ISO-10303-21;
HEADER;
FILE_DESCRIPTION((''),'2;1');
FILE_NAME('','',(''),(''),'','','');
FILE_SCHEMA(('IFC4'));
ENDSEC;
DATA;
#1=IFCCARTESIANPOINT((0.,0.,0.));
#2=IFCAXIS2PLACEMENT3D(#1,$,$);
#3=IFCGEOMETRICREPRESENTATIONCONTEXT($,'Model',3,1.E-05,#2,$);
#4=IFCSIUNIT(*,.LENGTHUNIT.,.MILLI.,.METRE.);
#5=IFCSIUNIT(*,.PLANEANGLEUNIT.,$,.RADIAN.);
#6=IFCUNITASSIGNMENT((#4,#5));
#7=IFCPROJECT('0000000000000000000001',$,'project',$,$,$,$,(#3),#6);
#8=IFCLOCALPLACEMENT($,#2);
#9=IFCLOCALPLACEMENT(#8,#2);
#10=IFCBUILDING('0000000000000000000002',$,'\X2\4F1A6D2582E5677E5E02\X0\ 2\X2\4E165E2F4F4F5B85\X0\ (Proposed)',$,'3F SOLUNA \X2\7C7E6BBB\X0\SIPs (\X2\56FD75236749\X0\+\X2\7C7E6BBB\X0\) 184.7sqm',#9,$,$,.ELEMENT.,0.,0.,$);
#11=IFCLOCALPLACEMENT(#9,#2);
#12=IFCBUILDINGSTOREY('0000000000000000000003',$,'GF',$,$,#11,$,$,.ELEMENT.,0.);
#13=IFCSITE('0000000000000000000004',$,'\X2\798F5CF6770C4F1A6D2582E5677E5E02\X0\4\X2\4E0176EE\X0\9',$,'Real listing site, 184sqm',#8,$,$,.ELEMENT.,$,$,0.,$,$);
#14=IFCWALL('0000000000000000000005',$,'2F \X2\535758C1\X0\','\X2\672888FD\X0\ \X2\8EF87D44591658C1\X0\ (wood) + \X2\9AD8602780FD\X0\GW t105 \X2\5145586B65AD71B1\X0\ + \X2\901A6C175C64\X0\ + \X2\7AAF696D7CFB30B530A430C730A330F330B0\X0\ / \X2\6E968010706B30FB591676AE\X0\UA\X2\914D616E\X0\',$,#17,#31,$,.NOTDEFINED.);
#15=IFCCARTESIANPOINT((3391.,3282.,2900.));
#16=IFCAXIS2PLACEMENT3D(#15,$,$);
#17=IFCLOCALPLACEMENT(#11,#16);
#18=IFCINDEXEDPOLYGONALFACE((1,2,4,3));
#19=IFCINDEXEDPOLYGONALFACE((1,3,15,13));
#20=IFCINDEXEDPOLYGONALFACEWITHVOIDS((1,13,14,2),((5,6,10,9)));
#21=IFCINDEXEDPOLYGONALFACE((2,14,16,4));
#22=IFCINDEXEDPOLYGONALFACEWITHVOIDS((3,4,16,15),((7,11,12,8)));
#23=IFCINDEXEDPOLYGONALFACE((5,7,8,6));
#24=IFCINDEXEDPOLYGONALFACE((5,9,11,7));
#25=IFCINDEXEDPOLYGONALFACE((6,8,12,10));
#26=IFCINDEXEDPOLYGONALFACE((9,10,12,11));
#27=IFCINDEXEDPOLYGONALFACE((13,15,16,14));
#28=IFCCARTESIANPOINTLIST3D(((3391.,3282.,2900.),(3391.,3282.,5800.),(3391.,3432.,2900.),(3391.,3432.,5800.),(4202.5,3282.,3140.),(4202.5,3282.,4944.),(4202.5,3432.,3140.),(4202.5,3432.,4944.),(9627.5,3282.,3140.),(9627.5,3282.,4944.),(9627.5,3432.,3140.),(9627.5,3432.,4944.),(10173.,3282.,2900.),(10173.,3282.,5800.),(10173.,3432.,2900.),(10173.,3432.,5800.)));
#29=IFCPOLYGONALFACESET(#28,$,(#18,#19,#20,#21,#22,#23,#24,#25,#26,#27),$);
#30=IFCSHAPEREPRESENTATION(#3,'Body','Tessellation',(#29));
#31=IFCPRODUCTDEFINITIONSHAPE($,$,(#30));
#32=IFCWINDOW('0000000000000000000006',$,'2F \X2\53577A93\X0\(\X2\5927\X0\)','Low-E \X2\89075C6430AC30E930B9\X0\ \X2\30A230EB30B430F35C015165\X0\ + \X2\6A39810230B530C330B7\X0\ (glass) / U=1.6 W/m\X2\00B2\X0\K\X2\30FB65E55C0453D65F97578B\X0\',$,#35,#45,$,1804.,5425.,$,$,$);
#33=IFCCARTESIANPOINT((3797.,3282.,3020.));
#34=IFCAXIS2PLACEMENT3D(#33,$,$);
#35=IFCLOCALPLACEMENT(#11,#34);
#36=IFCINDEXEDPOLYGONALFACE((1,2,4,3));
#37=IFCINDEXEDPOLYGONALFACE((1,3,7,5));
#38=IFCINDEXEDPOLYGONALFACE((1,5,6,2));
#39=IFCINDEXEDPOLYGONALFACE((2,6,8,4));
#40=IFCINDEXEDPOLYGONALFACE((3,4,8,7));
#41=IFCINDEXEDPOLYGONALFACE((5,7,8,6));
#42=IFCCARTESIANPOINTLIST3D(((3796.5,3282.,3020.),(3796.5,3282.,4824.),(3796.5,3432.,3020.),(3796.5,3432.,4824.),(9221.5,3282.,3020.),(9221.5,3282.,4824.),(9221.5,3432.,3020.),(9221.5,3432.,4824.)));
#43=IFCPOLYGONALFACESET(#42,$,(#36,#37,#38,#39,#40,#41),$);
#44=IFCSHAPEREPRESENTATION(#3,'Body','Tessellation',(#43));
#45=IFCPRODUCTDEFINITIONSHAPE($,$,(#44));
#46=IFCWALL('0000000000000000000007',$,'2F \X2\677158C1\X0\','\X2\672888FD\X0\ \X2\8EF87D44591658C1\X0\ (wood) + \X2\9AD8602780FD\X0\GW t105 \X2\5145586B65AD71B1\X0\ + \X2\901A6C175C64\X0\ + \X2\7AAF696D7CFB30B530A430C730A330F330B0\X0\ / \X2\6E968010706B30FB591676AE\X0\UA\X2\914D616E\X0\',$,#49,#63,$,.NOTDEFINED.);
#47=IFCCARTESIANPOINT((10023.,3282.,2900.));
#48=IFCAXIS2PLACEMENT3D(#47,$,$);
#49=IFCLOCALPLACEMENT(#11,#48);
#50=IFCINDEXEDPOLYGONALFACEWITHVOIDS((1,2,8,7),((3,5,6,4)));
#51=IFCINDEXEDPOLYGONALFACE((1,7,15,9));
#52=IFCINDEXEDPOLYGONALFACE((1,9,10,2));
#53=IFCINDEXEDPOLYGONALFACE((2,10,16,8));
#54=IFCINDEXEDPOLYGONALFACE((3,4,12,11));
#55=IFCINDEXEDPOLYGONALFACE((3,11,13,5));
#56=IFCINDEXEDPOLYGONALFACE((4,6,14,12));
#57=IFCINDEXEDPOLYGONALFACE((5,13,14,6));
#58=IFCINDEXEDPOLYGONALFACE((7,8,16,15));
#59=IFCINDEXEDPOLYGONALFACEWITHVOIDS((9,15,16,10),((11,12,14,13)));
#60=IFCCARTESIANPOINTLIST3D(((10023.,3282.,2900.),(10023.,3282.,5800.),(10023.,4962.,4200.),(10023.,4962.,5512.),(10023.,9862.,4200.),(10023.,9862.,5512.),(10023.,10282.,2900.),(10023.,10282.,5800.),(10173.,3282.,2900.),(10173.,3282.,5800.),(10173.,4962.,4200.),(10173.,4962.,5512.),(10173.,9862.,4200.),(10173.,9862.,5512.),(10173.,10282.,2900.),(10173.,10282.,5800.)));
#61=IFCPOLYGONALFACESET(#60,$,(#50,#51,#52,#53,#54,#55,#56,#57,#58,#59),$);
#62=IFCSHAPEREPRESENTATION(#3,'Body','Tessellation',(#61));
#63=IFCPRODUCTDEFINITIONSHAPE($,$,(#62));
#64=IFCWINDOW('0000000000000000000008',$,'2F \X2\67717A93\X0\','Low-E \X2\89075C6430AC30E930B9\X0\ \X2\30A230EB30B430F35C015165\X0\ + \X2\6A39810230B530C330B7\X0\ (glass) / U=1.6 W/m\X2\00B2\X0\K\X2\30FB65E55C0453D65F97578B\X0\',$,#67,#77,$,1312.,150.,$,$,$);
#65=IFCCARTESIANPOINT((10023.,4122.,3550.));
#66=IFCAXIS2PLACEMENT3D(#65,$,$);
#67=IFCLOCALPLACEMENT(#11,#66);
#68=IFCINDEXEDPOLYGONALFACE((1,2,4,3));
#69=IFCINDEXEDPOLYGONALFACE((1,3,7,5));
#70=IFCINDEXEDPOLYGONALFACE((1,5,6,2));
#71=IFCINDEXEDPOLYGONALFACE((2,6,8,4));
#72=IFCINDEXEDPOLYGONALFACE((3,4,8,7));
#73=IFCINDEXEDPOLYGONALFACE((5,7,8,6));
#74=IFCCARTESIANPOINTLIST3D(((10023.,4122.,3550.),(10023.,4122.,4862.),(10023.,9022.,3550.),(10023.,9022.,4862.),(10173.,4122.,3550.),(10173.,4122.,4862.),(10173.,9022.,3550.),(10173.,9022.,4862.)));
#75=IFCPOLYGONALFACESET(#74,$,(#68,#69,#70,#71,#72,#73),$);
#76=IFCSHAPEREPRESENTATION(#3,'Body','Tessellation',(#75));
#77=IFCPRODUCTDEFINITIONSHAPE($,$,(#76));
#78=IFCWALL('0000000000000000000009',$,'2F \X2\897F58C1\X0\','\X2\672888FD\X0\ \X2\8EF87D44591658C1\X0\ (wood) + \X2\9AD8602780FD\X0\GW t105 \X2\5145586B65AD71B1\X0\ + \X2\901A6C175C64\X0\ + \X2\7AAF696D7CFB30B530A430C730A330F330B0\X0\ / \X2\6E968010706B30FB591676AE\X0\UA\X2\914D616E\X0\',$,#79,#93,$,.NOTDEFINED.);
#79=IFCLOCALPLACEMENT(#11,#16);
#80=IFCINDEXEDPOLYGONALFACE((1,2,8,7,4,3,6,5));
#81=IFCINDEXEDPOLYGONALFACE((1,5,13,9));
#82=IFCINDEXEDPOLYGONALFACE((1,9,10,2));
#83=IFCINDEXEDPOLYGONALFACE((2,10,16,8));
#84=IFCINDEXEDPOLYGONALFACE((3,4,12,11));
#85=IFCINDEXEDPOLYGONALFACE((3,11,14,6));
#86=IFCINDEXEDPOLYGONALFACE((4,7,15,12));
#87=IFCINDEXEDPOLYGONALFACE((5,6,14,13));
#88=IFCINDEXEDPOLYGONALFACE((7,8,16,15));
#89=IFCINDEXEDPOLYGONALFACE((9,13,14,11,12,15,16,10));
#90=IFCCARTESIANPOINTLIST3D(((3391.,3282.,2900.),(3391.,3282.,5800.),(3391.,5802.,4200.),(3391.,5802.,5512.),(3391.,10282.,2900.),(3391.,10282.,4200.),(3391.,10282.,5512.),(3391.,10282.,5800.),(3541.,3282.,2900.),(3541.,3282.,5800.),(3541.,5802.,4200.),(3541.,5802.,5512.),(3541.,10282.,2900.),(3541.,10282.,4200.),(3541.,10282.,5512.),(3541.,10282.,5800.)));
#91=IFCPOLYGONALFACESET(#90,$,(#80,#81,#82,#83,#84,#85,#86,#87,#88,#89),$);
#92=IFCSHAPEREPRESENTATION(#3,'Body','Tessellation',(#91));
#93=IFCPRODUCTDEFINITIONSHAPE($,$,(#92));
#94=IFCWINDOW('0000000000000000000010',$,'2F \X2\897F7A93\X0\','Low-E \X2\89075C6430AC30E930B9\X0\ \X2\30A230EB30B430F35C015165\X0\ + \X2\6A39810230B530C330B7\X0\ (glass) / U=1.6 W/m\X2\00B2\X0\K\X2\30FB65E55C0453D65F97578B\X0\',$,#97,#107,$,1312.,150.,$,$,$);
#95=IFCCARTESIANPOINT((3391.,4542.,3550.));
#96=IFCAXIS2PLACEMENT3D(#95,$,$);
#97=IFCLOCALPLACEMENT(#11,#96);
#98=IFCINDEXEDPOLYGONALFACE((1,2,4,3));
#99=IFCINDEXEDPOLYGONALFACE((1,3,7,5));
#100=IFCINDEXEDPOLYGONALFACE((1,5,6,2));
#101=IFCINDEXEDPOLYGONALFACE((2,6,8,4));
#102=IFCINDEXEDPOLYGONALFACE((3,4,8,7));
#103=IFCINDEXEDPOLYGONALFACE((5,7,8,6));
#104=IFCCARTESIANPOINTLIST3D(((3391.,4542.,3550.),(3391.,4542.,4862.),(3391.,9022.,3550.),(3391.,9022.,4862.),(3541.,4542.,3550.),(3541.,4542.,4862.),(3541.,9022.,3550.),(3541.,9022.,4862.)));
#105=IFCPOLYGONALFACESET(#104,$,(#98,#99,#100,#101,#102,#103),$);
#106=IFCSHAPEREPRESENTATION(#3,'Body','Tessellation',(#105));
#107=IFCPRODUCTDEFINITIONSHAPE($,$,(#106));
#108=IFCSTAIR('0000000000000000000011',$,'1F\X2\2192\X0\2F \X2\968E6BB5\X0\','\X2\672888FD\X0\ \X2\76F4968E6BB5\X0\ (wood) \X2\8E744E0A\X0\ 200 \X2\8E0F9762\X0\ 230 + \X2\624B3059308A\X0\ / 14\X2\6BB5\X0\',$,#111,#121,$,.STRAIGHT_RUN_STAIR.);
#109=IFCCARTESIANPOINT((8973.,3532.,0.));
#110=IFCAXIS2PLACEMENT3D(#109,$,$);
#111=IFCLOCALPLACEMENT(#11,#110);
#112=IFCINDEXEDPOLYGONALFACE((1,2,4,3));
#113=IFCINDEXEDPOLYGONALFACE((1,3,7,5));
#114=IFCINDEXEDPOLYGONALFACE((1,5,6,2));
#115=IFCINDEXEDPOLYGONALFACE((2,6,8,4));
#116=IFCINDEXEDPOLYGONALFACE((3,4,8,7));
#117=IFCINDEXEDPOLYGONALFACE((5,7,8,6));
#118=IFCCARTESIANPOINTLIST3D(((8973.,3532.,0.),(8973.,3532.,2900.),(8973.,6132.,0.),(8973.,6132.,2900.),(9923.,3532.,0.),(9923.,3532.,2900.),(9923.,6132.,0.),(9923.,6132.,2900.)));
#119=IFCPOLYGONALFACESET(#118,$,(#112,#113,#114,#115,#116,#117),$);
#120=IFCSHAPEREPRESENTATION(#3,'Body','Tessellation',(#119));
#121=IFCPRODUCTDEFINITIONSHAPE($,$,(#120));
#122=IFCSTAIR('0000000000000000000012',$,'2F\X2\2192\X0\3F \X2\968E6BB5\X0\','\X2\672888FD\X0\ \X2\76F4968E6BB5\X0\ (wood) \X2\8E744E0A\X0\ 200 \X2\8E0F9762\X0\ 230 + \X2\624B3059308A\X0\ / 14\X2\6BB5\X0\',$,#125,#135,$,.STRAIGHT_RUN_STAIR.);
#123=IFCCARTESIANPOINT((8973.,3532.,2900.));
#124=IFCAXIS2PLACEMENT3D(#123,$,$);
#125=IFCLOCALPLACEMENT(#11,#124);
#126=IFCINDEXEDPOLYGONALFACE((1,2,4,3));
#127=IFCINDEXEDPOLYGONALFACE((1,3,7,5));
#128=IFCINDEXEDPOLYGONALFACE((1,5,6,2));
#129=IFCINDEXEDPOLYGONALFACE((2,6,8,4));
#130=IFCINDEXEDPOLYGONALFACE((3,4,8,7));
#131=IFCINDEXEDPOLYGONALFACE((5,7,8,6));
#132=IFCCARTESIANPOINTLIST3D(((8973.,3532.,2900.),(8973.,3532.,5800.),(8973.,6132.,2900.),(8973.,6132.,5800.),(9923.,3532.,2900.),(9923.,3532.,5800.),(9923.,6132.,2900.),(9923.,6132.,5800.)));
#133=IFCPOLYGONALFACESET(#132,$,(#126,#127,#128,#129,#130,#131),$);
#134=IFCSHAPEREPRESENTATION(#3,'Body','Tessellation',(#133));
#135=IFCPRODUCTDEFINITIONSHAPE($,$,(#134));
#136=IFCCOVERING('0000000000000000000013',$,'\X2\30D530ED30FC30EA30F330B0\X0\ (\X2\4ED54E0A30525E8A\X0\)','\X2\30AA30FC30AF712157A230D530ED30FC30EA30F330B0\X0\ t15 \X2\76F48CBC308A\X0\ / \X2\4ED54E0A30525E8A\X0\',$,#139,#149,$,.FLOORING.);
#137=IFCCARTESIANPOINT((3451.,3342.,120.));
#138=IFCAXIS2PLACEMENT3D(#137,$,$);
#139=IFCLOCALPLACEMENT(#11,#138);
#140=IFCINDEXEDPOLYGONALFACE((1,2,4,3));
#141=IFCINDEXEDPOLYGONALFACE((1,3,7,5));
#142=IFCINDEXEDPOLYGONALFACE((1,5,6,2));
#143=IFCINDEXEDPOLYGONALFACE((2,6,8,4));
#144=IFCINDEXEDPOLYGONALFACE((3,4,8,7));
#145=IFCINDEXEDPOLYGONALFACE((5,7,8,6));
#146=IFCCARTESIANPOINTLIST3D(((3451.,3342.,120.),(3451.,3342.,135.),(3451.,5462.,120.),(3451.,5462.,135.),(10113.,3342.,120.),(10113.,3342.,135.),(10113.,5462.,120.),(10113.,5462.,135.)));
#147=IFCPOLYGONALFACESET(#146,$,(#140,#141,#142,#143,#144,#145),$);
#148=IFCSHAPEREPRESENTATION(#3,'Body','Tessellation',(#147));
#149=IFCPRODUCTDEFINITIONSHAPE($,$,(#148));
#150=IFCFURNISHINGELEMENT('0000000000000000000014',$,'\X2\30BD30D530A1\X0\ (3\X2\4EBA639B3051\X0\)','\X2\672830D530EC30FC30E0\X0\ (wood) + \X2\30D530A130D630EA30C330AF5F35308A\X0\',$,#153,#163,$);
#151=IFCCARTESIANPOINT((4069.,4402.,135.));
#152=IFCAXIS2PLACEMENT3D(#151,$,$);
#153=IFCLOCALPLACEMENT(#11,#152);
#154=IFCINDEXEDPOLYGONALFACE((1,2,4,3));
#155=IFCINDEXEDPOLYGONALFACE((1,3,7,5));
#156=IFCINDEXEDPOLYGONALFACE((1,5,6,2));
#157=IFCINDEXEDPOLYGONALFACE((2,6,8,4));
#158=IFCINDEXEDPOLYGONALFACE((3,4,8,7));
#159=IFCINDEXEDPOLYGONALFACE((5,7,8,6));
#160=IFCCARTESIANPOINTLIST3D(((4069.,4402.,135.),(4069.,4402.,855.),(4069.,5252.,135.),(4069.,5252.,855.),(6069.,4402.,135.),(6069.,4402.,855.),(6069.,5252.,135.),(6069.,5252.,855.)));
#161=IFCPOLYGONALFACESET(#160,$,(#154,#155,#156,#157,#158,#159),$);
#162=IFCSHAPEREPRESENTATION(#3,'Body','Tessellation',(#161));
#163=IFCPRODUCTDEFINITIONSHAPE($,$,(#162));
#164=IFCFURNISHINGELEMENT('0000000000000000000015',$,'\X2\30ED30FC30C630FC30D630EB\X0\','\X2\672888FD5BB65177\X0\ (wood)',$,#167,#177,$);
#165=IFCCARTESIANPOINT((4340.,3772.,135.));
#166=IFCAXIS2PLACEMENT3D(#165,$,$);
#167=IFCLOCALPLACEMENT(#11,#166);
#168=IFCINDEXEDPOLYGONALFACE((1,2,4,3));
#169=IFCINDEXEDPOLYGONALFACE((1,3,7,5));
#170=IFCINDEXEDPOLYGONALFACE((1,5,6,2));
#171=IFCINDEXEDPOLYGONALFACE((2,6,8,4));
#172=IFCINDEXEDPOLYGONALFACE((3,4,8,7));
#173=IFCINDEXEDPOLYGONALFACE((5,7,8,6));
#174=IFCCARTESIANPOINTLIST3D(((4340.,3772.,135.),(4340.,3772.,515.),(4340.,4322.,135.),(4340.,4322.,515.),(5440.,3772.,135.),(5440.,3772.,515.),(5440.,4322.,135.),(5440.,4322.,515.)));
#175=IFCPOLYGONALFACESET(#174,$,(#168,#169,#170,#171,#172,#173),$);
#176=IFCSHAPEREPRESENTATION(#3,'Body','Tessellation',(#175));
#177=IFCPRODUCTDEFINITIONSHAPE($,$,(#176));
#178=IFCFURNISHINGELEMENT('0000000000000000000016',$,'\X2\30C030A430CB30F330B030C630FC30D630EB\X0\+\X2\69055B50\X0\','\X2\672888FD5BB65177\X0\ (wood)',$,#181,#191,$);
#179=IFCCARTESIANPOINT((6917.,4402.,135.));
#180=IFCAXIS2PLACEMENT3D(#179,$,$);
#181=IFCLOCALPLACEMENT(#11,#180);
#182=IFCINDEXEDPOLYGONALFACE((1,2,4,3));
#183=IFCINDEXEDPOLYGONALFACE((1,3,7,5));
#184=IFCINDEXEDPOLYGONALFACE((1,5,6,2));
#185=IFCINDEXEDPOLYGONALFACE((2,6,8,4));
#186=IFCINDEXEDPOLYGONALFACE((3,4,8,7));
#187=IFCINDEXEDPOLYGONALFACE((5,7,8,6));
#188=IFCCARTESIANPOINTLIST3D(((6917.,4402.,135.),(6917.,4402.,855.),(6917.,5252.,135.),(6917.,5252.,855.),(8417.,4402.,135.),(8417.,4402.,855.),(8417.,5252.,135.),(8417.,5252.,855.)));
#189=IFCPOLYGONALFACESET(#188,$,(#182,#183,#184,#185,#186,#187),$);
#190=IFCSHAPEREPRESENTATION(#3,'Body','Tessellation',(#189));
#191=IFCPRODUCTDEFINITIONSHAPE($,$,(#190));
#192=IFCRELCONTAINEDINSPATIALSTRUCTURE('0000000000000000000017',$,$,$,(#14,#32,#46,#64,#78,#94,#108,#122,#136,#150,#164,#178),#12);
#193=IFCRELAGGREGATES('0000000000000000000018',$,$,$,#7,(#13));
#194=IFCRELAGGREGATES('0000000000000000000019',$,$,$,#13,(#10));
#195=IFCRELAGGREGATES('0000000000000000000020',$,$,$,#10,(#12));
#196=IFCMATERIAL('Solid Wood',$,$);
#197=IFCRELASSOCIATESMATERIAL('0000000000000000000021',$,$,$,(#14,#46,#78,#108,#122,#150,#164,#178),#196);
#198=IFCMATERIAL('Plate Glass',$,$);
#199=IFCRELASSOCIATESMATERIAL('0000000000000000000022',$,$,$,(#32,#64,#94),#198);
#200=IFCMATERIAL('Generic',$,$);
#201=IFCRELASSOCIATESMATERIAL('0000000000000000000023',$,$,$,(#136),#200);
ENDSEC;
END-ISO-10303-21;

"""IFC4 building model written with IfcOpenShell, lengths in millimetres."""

from ifc_helpers import new_model, si_unit, frame, frame_2d, origin, place, context, project, spatial, rectangle, extrude, material, element, fill, save


model = new_model("IFC4")

# Units and contexts
model_context = context("Model", 3, precision=1e-05, world=origin())
ifc_project = project(units=[si_unit("LENGTHUNIT", "METRE", prefix="MILLI"), si_unit("PLANEANGLEUNIT", "RADIAN")], contexts=[model_context])

# Site, building, storey
site_placement = place(None, origin())
site = spatial("IfcSite", under=ifc_project, at=site_placement, Name="福島県会津若松市4丁目9", ObjectType="Real listing site, 184sqm", CompositionType="ELEMENT", RefElevation=0.0)
building_placement = place(site_placement, origin())
building = spatial("IfcBuilding", under=site, at=building_placement, Name="会津若松市 2世帯住宅 (Proposed)", ObjectType="3F SOLUNA 籾殻SIPs (国産杉+籾殻) 184.7sqm", CompositionType="ELEMENT", ElevationOfRefHeight=0.0, ElevationOfTerrain=0.0)
storey_placement = place(building_placement, origin())
storey = spatial("IfcBuildingStorey", under=building, at=storey_placement, Name="GF", CompositionType="ELEMENT", Elevation=0.0)

# Shared definitions
ifc_material_1 = material(Name="Solid Wood")
ifc_material_2 = material(Name="Generic")

# Shared definitions
ifc_material_3 = material(Name="Plate Glass")

# Walls, openings, windows
wall_1_placement = place(storey_placement, frame((3391.0, 3282.0, 2900.0)))
wall_1 = element("IfcWall", 1, at=wall_1_placement, inside=storey, material=ifc_material_1, Name="2F 南壁", Description="木製 軸組外壁 (wood) + 高性能GW t105 充填断熱 + 通気層 + 窯業系サイディング / 準耐火・外皮UA配慮", PredefinedType="NOTDEFINED", context=model_context, shape_type="SweptSolid", body=[
    extrude(rectangle(XDim=6782.0, YDim=150.0, at=frame_2d((3391.0, 75.0))), frame((3391.0, 3282.0, 2900.0)), (0.0, 0.0, 1.0), 2900.0),
])
opening_1_placement = place(storey_placement, frame((3797.0, 3282.0, 3020.0)))
opening_1 = element("IfcOpeningElement", 2, at=opening_1_placement, cuts=wall_1, PredefinedType="NOTDEFINED", context=model_context, shape_type="SweptSolid", body=[
    extrude(rectangle(XDim=5425.0, YDim=150.0, at=frame_2d((2712.0, 75.0))), frame((3797.0, 3282.0, 3020.0)), (0.0, 0.0, 1.0), 1804.0),
])
window_1_placement = place(storey_placement, frame((3797.0, 3282.0, 3020.0)))
window_1 = element("IfcWindow", 3, at=window_1_placement, inside=storey, material=ifc_material_3, Name="2F 南窓(大)", Description="Low-E 複層ガラス アルゴン封入 + 樹脂サッシ (glass) / U=1.6 W/m²K・日射取得型", OverallHeight=1804.0, OverallWidth=5425.0, context=model_context, shape_type="SweptSolid", body=[
    extrude(rectangle(XDim=5425.0, YDim=150.0, at=frame_2d((2712.0, 75.0))), frame((3797.0, 3282.0, 3020.0)), (0.0, 0.0, 1.0), 1804.0),
])
fill(opening_1, window_1)
wall_2_placement = place(storey_placement, frame((10023.0, 3282.0, 2900.0)))
wall_2 = element("IfcWall", 4, at=wall_2_placement, inside=storey, material=ifc_material_1, Name="2F 東壁", Description="木製 軸組外壁 (wood) + 高性能GW t105 充填断熱 + 通気層 + 窯業系サイディング / 準耐火・外皮UA配慮", PredefinedType="NOTDEFINED", context=model_context, shape_type="SweptSolid", body=[
    extrude(rectangle(XDim=150.0, YDim=7000.0, at=frame_2d((75.0, 3500.0))), frame((10023.0, 3282.0, 2900.0)), (0.0, 0.0, 1.0), 2900.0),
])
opening_2_placement = place(storey_placement, frame((10023.0, 4122.0, 3550.0)))
opening_2 = element("IfcOpeningElement", 5, at=opening_2_placement, cuts=wall_2, PredefinedType="NOTDEFINED", context=model_context, shape_type="SweptSolid", body=[
    extrude(rectangle(XDim=150.0, YDim=4900.0, at=frame_2d((75.0, 2450.0))), frame((10023.0, 4122.0, 3550.0)), (0.0, 0.0, 1.0), 1312.0),
])
window_2_placement = place(storey_placement, frame((10023.0, 4122.0, 3550.0)))
window_2 = element("IfcWindow", 6, at=window_2_placement, inside=storey, material=ifc_material_3, Name="2F 東窓", Description="Low-E 複層ガラス アルゴン封入 + 樹脂サッシ (glass) / U=1.6 W/m²K・日射取得型", OverallHeight=1312.0, OverallWidth=150.0, context=model_context, shape_type="SweptSolid", body=[
    extrude(rectangle(XDim=150.0, YDim=4900.0, at=frame_2d((75.0, 2450.0))), frame((10023.0, 4122.0, 3550.0)), (0.0, 0.0, 1.0), 1312.0),
])
fill(opening_2, window_2)
wall_3_placement = place(storey_placement, frame((3391.0, 3282.0, 2900.0)))
wall_3 = element("IfcWall", 7, at=wall_3_placement, inside=storey, material=ifc_material_1, Name="2F 西壁", Description="木製 軸組外壁 (wood) + 高性能GW t105 充填断熱 + 通気層 + 窯業系サイディング / 準耐火・外皮UA配慮", PredefinedType="NOTDEFINED", context=model_context, shape_type="SweptSolid", body=[
    extrude(rectangle(XDim=150.0, YDim=7000.0, at=frame_2d((75.0, 3500.0))), frame((3391.0, 3282.0, 2900.0)), (0.0, 0.0, 1.0), 2900.0),
])
opening_3_placement = place(storey_placement, frame((3391.0, 4542.0, 3550.0)))
opening_3 = element("IfcOpeningElement", 8, at=opening_3_placement, cuts=wall_3, PredefinedType="NOTDEFINED", context=model_context, shape_type="SweptSolid", body=[
    extrude(rectangle(XDim=150.0, YDim=4480.0, at=frame_2d((75.0, 2240.0))), frame((3391.0, 4542.0, 3550.0)), (0.0, 0.0, 1.0), 1312.0),
])
window_3_placement = place(storey_placement, frame((3391.0, 4542.0, 3550.0)))
window_3 = element("IfcWindow", 9, at=window_3_placement, inside=storey, material=ifc_material_3, Name="2F 西窓", Description="Low-E 複層ガラス アルゴン封入 + 樹脂サッシ (glass) / U=1.6 W/m²K・日射取得型", OverallHeight=1312.0, OverallWidth=150.0, context=model_context, shape_type="SweptSolid", body=[
    extrude(rectangle(XDim=150.0, YDim=4480.0, at=frame_2d((75.0, 2240.0))), frame((3391.0, 4542.0, 3550.0)), (0.0, 0.0, 1.0), 1312.0),
])
fill(opening_3, window_3)

# Stairs
stair_1_placement = place(storey_placement, frame((8973.0, 3532.0, 0.0)))
element("IfcStair", 10, at=stair_1_placement, inside=storey, material=ifc_material_1, Name="1F→2F 階段", Description="木製 直階段 (wood) 蹴上 200 踏面 230 + 手すり / 14段", PredefinedType="STRAIGHT_RUN_STAIR", context=model_context, shape_type="SweptSolid", body=[
    extrude(rectangle(XDim=950.0, YDim=2600.0, at=frame_2d((475.0, 1300.0))), frame((8973.0, 3532.0, 0.0)), (0.0, 0.0, 1.0), 2900.0),
])
stair_2_placement = place(storey_placement, frame((8973.0, 3532.0, 2900.0)))
element("IfcStair", 11, at=stair_2_placement, inside=storey, material=ifc_material_1, Name="2F→3F 階段", Description="木製 直階段 (wood) 蹴上 200 踏面 230 + 手すり / 14段", PredefinedType="STRAIGHT_RUN_STAIR", context=model_context, shape_type="SweptSolid", body=[
    extrude(rectangle(XDim=950.0, YDim=2600.0, at=frame_2d((475.0, 1300.0))), frame((8973.0, 3532.0, 2900.0)), (0.0, 0.0, 1.0), 2900.0),
])

# Covering
covering_placement = place(storey_placement, frame((3451.0, 3342.0, 120.0)))
element("IfcCovering", 12, at=covering_placement, inside=storey, material=ifc_material_2, Name="フローリング (仕上げ床)", Description="オーク無垢フローリング t15 直貼り / 仕上げ床", PredefinedType="FLOORING", context=model_context, shape_type="SweptSolid", body=[
    extrude(rectangle(XDim=6662.0, YDim=2120.0, at=frame_2d((3331.0, 1060.0))), frame((3451.0, 3342.0, 120.0)), (0.0, 0.0, 1.0), 15.0),
])

# Furnishing elements
furnishing_1_placement = place(storey_placement, frame((4069.0, 4402.0, 135.0)))
element("IfcFurnishingElement", 13, at=furnishing_1_placement, inside=storey, material=ifc_material_1, Name="ソファ (3人掛け)", Description="木フレーム (wood) + ファブリック張り", context=model_context, shape_type="SweptSolid", body=[
    extrude(rectangle(XDim=2000.0, YDim=850.0, at=frame_2d((1000.0, 425.0))), frame((4069.0, 4402.0, 135.0)), (0.0, 0.0, 1.0), 720.0),
])
furnishing_2_placement = place(storey_placement, frame((4340.0, 3772.0, 135.0)))
element("IfcFurnishingElement", 14, at=furnishing_2_placement, inside=storey, material=ifc_material_1, Name="ローテーブル", Description="木製家具 (wood)", context=model_context, shape_type="SweptSolid", body=[
    extrude(rectangle(XDim=1100.0, YDim=550.0, at=frame_2d((550.0, 275.0))), frame((4340.0, 3772.0, 135.0)), (0.0, 0.0, 1.0), 380.0),
])
furnishing_3_placement = place(storey_placement, frame((6917.0, 4402.0, 135.0)))
element("IfcFurnishingElement", 15, at=furnishing_3_placement, inside=storey, material=ifc_material_1, Name="ダイニングテーブル+椅子", Description="木製家具 (wood)", context=model_context, shape_type="SweptSolid", body=[
    extrude(rectangle(XDim=1500.0, YDim=850.0, at=frame_2d((750.0, 425.0))), frame((6917.0, 4402.0, 135.0)), (0.0, 0.0, 1.0), 720.0),
])

save(model, "model.ifc")
